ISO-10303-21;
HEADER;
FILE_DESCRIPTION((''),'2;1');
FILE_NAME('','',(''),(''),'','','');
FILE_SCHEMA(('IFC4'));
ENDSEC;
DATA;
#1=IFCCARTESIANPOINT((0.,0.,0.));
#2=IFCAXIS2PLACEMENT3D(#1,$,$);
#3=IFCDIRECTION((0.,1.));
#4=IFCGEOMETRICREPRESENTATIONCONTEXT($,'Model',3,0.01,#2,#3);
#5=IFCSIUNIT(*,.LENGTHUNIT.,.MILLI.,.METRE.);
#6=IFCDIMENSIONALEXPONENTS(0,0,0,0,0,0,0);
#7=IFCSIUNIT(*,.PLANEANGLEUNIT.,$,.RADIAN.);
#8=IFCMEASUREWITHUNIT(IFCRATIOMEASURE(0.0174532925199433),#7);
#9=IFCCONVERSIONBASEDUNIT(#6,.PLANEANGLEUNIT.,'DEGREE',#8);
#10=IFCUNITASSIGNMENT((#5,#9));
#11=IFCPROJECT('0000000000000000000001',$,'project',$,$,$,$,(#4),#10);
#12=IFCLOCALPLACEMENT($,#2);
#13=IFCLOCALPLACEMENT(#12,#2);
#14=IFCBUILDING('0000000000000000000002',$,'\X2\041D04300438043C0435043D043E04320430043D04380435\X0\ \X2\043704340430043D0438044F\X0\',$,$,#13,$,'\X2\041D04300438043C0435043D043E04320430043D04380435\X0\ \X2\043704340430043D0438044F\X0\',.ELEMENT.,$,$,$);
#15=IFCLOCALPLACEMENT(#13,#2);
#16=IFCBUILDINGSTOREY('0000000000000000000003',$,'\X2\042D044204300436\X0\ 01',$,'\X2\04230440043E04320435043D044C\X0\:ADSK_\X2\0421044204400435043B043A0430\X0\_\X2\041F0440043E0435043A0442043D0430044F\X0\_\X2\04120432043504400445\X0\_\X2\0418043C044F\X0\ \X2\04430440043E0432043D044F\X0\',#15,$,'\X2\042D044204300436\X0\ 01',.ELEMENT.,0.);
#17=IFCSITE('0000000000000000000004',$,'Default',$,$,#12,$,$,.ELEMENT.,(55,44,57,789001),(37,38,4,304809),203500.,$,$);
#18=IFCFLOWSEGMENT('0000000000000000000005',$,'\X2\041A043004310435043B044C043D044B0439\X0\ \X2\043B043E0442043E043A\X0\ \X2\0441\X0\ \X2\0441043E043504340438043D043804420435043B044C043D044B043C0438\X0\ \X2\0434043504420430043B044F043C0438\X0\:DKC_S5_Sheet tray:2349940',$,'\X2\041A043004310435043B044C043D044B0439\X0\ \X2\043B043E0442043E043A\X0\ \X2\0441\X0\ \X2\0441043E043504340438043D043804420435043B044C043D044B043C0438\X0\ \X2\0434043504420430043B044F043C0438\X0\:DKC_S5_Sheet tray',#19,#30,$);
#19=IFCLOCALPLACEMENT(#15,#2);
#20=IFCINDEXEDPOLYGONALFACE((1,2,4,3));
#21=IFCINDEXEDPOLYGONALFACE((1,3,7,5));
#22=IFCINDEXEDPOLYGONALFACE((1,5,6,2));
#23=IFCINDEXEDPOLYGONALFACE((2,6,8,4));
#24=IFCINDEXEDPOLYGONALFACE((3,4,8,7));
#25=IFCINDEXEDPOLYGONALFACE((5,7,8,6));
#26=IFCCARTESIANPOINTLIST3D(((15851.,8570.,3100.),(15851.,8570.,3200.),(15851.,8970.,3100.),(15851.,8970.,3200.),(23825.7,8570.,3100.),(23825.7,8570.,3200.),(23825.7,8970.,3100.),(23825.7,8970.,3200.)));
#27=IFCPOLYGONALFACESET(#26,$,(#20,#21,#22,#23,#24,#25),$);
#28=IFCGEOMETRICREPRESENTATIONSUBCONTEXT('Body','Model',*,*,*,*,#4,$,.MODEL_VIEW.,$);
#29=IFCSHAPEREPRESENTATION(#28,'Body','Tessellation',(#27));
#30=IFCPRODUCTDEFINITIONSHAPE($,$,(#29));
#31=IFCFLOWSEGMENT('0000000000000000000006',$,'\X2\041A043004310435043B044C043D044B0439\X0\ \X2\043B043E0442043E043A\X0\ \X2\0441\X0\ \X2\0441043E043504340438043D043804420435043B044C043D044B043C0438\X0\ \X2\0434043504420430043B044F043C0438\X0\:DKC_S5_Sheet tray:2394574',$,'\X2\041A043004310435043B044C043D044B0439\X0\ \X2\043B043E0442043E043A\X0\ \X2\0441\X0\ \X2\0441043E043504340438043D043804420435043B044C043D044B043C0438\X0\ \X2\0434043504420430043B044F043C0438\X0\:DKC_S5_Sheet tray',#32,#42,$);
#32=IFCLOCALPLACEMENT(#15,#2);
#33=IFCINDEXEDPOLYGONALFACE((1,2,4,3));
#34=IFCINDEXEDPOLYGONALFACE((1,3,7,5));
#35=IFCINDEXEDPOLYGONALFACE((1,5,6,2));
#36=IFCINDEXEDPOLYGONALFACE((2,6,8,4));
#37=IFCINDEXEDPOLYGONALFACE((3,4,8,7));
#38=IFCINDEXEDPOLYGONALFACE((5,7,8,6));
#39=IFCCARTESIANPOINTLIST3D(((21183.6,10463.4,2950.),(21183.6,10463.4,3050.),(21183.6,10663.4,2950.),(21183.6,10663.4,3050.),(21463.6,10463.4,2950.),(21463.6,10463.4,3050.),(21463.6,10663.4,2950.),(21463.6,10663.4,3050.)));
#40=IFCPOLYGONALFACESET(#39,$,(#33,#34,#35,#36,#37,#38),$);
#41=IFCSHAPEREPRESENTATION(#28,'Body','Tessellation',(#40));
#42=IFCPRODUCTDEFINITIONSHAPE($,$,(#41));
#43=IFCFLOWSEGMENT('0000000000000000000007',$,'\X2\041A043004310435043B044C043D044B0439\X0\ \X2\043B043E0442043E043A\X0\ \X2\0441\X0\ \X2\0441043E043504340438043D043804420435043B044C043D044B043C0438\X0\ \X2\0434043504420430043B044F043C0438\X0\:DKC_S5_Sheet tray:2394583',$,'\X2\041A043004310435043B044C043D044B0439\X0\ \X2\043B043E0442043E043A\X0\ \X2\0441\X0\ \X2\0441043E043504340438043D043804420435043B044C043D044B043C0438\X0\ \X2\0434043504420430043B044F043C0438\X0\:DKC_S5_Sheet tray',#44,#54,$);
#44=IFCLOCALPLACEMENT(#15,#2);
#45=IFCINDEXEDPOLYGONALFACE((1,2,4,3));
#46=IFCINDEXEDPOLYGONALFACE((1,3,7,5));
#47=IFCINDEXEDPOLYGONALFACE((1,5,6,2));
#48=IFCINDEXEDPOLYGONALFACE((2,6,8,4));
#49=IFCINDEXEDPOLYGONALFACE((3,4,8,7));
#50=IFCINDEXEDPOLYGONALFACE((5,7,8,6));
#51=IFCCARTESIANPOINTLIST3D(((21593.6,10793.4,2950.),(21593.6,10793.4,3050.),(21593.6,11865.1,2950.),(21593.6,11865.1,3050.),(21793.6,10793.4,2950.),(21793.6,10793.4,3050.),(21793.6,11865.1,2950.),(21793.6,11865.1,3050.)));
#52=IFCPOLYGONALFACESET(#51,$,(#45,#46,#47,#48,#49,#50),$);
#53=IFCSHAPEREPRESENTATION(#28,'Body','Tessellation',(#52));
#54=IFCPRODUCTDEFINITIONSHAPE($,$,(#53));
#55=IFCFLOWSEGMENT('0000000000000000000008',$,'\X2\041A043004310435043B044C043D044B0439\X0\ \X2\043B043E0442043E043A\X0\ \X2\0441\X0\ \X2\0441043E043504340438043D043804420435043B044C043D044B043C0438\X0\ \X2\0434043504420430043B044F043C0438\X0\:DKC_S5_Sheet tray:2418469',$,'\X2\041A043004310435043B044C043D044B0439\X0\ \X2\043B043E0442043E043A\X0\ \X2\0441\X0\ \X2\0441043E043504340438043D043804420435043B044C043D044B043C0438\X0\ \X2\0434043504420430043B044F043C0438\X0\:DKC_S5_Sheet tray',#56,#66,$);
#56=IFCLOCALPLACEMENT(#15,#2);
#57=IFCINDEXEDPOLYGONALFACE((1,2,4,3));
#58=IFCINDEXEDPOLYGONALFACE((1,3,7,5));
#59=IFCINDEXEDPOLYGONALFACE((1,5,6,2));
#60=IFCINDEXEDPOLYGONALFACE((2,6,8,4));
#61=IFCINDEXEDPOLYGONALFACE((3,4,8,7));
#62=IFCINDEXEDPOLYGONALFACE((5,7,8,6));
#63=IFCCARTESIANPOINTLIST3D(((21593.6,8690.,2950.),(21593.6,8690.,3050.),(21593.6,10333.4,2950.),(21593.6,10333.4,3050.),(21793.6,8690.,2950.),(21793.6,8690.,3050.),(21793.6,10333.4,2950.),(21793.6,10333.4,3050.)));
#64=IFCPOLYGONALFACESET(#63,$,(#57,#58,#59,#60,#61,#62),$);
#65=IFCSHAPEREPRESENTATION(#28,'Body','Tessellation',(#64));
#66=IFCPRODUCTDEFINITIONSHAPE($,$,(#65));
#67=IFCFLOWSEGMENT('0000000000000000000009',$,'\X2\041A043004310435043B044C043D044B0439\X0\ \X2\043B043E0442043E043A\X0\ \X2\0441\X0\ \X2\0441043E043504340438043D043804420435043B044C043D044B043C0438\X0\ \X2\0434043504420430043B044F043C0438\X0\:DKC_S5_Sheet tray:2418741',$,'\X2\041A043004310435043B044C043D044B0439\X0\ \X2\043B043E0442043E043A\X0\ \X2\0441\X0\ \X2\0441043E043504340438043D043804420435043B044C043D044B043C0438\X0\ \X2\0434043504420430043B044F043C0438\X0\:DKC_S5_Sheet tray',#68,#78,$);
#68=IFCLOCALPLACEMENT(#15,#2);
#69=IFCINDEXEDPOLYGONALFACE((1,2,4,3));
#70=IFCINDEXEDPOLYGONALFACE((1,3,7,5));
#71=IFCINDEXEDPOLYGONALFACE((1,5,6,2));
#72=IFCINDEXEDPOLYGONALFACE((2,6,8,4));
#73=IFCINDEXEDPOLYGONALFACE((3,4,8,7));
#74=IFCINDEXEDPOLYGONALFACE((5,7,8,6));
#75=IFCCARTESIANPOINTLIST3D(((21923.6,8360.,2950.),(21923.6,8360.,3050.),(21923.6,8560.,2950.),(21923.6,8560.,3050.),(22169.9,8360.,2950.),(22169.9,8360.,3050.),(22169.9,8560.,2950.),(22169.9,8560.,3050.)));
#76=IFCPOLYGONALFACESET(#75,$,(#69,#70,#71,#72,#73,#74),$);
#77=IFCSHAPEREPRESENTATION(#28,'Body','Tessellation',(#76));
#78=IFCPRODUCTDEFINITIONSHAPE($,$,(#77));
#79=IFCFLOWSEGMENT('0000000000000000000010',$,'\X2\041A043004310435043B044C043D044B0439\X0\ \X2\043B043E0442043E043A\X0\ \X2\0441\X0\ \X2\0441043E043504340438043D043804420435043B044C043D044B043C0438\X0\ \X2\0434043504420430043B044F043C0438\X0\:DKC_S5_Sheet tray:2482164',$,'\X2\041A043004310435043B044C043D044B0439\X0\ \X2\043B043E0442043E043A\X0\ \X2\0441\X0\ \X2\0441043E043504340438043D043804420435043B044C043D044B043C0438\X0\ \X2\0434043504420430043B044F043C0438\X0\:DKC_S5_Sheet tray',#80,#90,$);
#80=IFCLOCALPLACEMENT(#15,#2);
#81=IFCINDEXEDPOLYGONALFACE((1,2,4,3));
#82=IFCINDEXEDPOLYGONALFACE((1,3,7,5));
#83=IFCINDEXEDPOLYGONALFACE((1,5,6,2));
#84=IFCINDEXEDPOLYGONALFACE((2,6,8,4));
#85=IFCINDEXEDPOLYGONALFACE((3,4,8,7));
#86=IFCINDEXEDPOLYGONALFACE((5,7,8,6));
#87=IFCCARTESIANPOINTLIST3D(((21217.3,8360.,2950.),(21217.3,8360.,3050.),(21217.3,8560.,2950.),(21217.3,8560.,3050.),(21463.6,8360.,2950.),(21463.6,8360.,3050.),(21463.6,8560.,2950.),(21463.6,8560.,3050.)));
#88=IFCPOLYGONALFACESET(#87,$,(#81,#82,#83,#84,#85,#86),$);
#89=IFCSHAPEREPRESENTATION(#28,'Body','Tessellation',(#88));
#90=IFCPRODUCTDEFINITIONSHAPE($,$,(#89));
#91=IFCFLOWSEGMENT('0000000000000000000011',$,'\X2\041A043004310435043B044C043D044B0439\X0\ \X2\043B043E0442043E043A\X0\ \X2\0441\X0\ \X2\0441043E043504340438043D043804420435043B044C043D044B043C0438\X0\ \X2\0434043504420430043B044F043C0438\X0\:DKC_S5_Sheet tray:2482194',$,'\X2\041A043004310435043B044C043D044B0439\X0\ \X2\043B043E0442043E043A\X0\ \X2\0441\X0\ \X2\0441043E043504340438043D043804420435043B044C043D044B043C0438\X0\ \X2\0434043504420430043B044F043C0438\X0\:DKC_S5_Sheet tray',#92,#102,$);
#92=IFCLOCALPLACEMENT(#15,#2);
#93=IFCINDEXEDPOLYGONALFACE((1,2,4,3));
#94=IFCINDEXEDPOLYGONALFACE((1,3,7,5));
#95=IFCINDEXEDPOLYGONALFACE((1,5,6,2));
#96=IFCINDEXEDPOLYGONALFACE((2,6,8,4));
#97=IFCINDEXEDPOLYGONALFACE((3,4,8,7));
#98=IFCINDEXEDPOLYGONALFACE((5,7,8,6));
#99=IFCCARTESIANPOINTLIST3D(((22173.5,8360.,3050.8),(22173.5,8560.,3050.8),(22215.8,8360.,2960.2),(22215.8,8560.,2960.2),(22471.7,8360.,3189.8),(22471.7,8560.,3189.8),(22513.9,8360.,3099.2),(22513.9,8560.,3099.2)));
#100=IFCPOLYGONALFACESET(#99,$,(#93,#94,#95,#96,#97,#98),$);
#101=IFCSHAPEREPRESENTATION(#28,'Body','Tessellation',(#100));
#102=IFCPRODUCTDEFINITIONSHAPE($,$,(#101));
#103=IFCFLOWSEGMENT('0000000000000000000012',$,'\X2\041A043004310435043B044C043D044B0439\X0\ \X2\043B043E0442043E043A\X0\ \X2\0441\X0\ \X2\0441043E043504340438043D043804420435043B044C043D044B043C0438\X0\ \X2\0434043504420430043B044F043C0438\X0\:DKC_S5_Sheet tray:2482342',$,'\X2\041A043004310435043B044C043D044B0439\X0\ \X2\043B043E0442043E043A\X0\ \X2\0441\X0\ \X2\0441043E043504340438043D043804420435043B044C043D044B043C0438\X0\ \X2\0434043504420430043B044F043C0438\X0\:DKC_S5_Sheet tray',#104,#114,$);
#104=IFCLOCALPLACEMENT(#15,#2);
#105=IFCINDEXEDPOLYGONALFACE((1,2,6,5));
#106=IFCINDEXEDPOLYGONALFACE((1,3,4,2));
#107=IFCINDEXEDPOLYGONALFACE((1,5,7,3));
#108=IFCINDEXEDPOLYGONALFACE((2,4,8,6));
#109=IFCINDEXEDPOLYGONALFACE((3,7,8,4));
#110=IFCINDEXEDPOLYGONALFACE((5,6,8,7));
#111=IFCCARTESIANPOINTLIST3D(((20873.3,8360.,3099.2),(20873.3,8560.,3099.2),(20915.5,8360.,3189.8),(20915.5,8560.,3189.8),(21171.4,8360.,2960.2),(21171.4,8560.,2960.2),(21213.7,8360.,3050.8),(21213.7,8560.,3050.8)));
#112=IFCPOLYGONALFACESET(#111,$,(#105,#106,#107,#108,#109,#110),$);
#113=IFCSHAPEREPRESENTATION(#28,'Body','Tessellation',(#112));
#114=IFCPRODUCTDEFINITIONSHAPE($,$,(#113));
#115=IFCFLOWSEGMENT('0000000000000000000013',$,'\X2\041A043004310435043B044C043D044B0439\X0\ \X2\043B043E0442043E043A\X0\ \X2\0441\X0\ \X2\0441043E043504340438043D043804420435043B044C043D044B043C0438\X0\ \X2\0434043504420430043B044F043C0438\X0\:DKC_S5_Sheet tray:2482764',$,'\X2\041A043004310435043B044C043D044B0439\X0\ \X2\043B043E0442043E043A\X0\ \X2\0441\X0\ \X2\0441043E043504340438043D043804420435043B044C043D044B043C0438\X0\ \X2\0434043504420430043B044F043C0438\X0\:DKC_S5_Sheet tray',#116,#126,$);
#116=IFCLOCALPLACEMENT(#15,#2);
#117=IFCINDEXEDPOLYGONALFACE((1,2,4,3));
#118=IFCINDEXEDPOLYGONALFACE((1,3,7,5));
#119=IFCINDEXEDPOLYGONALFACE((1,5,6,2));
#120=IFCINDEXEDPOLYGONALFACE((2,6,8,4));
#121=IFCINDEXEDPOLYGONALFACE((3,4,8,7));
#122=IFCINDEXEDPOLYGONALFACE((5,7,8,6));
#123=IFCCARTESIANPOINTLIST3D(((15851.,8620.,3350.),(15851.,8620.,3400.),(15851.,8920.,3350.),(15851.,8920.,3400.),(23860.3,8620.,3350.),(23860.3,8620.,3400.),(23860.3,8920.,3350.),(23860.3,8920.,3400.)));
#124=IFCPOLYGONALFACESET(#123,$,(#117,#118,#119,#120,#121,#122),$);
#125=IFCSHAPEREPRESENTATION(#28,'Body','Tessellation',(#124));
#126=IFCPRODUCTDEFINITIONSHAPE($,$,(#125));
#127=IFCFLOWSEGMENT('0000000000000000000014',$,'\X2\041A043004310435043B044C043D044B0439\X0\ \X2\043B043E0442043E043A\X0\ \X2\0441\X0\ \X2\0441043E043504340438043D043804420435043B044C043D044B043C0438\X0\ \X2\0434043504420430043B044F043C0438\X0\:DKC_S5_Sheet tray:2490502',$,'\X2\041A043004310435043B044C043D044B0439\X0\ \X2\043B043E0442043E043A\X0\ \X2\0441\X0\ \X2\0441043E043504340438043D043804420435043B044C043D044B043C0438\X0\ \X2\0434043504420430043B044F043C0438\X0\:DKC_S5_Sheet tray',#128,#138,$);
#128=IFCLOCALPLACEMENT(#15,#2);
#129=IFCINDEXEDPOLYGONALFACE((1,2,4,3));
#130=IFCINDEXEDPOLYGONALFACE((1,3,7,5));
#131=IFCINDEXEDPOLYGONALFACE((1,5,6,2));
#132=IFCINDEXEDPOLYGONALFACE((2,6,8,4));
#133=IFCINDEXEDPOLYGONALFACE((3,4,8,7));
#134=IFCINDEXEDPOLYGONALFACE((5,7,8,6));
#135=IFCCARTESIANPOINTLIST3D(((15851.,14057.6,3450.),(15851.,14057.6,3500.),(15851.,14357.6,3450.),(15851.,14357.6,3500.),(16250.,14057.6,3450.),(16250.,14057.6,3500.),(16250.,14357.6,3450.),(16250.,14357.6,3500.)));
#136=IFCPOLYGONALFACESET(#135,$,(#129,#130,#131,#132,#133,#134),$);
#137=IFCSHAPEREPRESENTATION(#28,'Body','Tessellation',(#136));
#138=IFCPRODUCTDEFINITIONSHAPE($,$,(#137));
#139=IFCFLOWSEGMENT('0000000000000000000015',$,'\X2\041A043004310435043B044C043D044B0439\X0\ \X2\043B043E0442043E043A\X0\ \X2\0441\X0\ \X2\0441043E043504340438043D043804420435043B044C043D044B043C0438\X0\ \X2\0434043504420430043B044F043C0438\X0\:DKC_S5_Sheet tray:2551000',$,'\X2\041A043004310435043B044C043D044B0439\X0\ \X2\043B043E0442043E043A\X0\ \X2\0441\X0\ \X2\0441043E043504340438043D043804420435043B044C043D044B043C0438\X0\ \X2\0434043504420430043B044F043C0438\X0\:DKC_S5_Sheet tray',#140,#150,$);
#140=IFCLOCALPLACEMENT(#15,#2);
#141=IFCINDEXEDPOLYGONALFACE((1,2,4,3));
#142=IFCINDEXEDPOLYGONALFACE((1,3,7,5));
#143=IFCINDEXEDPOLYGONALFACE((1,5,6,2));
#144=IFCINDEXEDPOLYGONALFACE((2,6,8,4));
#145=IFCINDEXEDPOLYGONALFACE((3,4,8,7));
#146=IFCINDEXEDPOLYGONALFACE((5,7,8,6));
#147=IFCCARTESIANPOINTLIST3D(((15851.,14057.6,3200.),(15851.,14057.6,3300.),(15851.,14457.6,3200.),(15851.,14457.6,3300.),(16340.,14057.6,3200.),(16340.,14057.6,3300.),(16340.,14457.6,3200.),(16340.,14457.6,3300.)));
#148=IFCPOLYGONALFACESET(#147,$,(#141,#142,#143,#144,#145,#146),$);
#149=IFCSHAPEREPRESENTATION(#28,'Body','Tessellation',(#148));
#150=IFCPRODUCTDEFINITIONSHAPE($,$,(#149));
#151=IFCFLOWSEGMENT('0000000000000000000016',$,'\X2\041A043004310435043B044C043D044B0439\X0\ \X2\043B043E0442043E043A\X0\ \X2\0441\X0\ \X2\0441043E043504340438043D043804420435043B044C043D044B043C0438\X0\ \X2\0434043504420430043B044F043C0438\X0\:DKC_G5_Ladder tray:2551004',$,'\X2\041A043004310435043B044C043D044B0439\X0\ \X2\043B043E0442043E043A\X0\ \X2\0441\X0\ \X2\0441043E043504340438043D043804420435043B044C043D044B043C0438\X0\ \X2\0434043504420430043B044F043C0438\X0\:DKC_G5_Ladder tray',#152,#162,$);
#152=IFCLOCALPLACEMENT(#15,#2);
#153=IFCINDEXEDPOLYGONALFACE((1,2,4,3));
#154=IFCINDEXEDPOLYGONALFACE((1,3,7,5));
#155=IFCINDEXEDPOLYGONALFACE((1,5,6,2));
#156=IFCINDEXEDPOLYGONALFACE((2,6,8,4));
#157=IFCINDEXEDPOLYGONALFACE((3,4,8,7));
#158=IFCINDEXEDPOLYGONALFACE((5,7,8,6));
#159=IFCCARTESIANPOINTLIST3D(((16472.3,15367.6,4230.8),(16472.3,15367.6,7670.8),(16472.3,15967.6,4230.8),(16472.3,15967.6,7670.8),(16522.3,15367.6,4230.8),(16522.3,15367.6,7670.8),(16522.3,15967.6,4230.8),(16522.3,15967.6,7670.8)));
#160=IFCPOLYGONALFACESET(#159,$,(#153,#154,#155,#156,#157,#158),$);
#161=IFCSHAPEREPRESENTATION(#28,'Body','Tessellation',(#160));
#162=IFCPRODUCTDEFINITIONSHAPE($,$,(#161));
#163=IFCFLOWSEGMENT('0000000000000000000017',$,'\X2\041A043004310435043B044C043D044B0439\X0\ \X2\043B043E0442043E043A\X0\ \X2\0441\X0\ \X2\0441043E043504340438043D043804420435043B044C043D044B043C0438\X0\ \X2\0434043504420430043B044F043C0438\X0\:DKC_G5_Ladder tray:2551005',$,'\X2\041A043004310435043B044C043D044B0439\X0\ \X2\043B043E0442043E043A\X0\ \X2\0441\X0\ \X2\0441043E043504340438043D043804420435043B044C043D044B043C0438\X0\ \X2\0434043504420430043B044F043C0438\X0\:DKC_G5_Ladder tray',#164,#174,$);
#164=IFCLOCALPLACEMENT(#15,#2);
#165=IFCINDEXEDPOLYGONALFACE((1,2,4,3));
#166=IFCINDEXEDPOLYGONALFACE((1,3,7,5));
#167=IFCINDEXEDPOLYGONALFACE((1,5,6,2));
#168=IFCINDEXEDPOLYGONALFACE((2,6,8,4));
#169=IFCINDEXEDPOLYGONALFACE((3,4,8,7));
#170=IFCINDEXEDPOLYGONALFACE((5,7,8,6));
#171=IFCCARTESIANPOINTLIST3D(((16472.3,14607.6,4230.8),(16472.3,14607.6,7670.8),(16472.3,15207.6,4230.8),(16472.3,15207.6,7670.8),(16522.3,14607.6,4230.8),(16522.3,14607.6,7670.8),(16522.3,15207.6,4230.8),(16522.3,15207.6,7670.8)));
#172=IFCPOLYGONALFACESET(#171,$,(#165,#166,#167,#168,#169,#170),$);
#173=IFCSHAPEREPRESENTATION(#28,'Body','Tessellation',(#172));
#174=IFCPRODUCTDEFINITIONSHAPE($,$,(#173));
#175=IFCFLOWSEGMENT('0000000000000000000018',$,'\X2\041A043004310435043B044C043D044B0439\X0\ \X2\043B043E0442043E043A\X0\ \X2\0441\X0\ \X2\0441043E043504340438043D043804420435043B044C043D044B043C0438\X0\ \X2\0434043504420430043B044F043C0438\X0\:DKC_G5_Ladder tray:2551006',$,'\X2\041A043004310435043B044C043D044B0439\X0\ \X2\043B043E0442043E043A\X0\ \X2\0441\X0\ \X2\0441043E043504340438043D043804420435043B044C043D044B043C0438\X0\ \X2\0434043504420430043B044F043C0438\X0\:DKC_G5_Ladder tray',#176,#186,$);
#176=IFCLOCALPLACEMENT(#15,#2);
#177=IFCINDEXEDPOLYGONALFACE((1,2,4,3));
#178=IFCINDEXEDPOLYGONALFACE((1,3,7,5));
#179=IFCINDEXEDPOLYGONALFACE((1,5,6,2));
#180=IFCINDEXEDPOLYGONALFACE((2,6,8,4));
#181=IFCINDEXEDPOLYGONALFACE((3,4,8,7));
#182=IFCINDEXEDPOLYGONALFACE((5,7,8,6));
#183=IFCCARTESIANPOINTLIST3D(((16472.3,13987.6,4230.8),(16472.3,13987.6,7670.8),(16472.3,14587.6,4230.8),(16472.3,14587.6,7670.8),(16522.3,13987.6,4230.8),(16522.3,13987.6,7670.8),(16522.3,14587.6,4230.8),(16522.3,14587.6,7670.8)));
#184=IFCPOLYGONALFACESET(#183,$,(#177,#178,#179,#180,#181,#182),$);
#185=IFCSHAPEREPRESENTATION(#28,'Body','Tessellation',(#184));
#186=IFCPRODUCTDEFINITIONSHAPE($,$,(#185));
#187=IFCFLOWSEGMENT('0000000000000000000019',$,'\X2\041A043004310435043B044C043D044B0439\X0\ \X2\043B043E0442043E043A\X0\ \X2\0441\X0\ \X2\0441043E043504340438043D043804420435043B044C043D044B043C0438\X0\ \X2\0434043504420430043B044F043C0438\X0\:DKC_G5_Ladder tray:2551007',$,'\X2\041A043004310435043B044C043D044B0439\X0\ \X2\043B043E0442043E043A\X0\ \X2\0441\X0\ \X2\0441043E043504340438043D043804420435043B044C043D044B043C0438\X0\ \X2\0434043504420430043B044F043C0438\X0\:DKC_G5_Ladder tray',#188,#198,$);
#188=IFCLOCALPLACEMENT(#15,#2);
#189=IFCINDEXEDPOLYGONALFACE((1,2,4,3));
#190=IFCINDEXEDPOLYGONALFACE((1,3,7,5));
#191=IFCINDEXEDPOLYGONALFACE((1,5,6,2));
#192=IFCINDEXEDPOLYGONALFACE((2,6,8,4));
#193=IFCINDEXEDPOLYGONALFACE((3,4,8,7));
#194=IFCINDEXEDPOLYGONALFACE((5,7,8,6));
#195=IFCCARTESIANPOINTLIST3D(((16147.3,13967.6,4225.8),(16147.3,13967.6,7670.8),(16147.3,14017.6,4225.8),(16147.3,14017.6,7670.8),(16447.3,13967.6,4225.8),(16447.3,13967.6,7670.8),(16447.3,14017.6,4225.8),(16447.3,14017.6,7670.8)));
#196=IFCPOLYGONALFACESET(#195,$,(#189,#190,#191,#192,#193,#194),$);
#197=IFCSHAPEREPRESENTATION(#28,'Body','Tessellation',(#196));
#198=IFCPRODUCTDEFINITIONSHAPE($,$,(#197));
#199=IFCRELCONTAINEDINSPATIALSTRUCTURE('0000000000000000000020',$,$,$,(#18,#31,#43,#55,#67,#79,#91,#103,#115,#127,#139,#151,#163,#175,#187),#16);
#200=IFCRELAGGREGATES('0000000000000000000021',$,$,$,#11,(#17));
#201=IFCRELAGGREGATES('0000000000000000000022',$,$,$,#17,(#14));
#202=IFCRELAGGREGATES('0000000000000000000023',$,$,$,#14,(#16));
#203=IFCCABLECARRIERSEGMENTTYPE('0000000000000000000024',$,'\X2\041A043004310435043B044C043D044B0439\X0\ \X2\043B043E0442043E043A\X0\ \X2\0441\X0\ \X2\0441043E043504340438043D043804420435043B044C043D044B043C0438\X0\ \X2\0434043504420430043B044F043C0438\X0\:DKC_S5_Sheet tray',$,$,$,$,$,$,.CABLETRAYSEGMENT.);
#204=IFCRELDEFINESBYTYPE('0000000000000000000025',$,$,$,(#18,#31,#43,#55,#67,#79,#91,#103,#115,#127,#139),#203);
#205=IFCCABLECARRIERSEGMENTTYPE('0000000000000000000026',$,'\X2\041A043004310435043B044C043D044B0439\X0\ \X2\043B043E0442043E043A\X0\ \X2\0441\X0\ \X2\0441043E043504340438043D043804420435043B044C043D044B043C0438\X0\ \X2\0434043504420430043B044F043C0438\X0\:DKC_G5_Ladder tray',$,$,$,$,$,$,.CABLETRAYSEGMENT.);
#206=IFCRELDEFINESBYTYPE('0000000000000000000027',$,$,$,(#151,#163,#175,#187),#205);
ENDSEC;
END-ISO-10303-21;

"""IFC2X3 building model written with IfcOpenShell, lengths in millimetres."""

from ifc_helpers import new_model, entity, si_unit, converted_unit, direction, frame, frame_2d, origin, origin_2d_with_axis, place, context, subcontext, project, spatial, rectangle, extrude, type_object, element, save


model = new_model("IFC2X3")

# Units and contexts
model_context = context("Model", 3, precision=0.01, world=origin(), true_north=direction((0.0, 1.0)))
body_context = subcontext(model_context, "Body", "Model", "MODEL_VIEW")
ifc_project = project(units=[si_unit("LENGTHUNIT", "METRE", prefix="MILLI"), converted_unit("PLANEANGLEUNIT", "DEGREE", entity("IfcRatioMeasure", 0.0174532925199433), si_unit("PLANEANGLEUNIT", "RADIAN"), dimensions=[0, 0, 0, 0, 0, 0, 0])], contexts=[model_context])

# Site, building, storey
site_placement = place(None, origin())
site = spatial("IfcSite", under=ifc_project, at=site_placement, Name="Default", CompositionType="ELEMENT", RefLatitude=(55, 44, 57, 789001), RefLongitude=(37, 38, 4, 304809), RefElevation=203500.0)
building_placement = place(site_placement, origin())
building = spatial("IfcBuilding", under=site, at=building_placement, Name="Наименование здания", LongName="Наименование здания", CompositionType="ELEMENT")
storey_placement = place(building_placement, origin())
storey = spatial("IfcBuildingStorey", under=building, at=storey_placement, Name="Этаж 01", ObjectType="Уровень:ADSK_Стрелка_Проектная_Вверх_Имя уровня", LongName="Этаж 01", CompositionType="ELEMENT", Elevation=0.0)

# Flow segments
cable_carrier_segment_type_1 = type_object("IfcCableCarrierSegmentType", Name="Кабельный лоток с соединительными деталями:DKC_S5_Sheet tray", PredefinedType="CABLETRAYSEGMENT")
flow_segment_1_placement = place(storey_placement, frame((15851.0, 8570.0, 3100.0)))
element("IfcFlowSegment", 1, at=flow_segment_1_placement, inside=storey, type_object=cable_carrier_segment_type_1, Name="Кабельный лоток с соединительными деталями:DKC_S5_Sheet tray:2349940", ObjectType="Кабельный лоток с соединительными деталями:DKC_S5_Sheet tray", context=body_context, shape_type="SweptSolid", body=[
    extrude(rectangle(XDim=7974.7, YDim=400.0, at=origin_2d_with_axis()), frame((3987.3, 200.0, 0.0)), (0.0, 0.0, 1.0), 100.0),
])
flow_segment_2_placement = place(storey_placement, frame((21183.6, 10463.4, 2950.0)))
element("IfcFlowSegment", 2, at=flow_segment_2_placement, inside=storey, type_object=cable_carrier_segment_type_1, Name="Кабельный лоток с соединительными деталями:DKC_S5_Sheet tray:2394574", ObjectType="Кабельный лоток с соединительными деталями:DKC_S5_Sheet tray", context=body_context, shape_type="SweptSolid", body=[
    extrude(rectangle(XDim=280.0, YDim=200.0, at=origin_2d_with_axis()), frame((140.0, 100.0, 0.0), z_axis=(0.0, 0.0, 1.0), x_axis=(-1.0, 0.0, 0.0)), (0.0, 0.0, 1.0), 100.0),
])
flow_segment_3_placement = place(storey_placement, frame((21593.6, 10793.4, 2950.0)))
element("IfcFlowSegment", 3, at=flow_segment_3_placement, inside=storey, type_object=cable_carrier_segment_type_1, Name="Кабельный лоток с соединительными деталями:DKC_S5_Sheet tray:2394583", ObjectType="Кабельный лоток с соединительными деталями:DKC_S5_Sheet tray", context=body_context, shape_type="SweptSolid", body=[
    extrude(rectangle(XDim=1071.7, YDim=200.0, at=origin_2d_with_axis()), frame((100.0, 535.9, 0.0), z_axis=(0.0, 0.0, 1.0), x_axis=(0.0, -1.0, 0.0)), (0.0, 0.0, 1.0), 100.0),
])
flow_segment_4_placement = place(storey_placement, frame((21593.6, 8690.0, 2950.0)))
element("IfcFlowSegment", 4, at=flow_segment_4_placement, inside=storey, type_object=cable_carrier_segment_type_1, Name="Кабельный лоток с соединительными деталями:DKC_S5_Sheet tray:2418469", ObjectType="Кабельный лоток с соединительными деталями:DKC_S5_Sheet tray", context=body_context, shape_type="SweptSolid", body=[
    extrude(rectangle(XDim=1643.4, YDim=200.0, at=origin_2d_with_axis()), frame((100.0, 821.7, 0.0), z_axis=(0.0, 0.0, 1.0), x_axis=(0.0, -1.0, 0.0)), (0.0, 0.0, 1.0), 100.0),
])
flow_segment_5_placement = place(storey_placement, frame((21923.6, 8360.0, 2950.0)))
element("IfcFlowSegment", 5, at=flow_segment_5_placement, inside=storey, type_object=cable_carrier_segment_type_1, Name="Кабельный лоток с соединительными деталями:DKC_S5_Sheet tray:2418741", ObjectType="Кабельный лоток с соединительными деталями:DKC_S5_Sheet tray", context=body_context, shape_type="SweptSolid", body=[
    extrude(rectangle(XDim=246.3, YDim=200.0, at=origin_2d_with_axis()), frame((123.2, 100.0, 0.0)), (0.0, 0.0, 1.0), 100.0),
])
flow_segment_6_placement = place(storey_placement, frame((21217.3, 8360.0, 2950.0)))
element("IfcFlowSegment", 6, at=flow_segment_6_placement, inside=storey, type_object=cable_carrier_segment_type_1, Name="Кабельный лоток с соединительными деталями:DKC_S5_Sheet tray:2482164", ObjectType="Кабельный лоток с соединительными деталями:DKC_S5_Sheet tray", context=body_context, shape_type="SweptSolid", body=[
    extrude(rectangle(XDim=246.3, YDim=200.0, at=origin_2d_with_axis()), frame((123.2, 100.0, 0.0), z_axis=(0.0, 0.0, 1.0), x_axis=(-1.0, 0.0, 0.0)), (0.0, 0.0, 1.0), 100.0),
])
flow_segment_7_placement = place(storey_placement, frame((22173.5, 8360.0, 2960.2)))
element("IfcFlowSegment", 7, at=flow_segment_7_placement, inside=storey, type_object=cable_carrier_segment_type_1, Name="Кабельный лоток с соединительными деталями:DKC_S5_Sheet tray:2482194", ObjectType="Кабельный лоток с соединительными деталями:DKC_S5_Sheet tray", context=body_context, shape_type="SweptSolid", body=[
    extrude(rectangle(XDim=100.0, YDim=200.0, at=origin_2d_with_axis()), frame((21.1, 100.0, 45.3), z_axis=(0.906308, 0.0, 0.422618), x_axis=(-0.422618, 0.0, 0.906308)), (0.0, 0.0, 1.0), 329.0),
])
flow_segment_8_placement = place(storey_placement, frame((20873.3, 8360.0, 2960.2)))
element("IfcFlowSegment", 8, at=flow_segment_8_placement, inside=storey, type_object=cable_carrier_segment_type_1, Name="Кабельный лоток с соединительными деталями:DKC_S5_Sheet tray:2482342", ObjectType="Кабельный лоток с соединительными деталями:DKC_S5_Sheet tray", context=body_context, shape_type="SweptSolid", body=[
    extrude(rectangle(XDim=100.0, YDim=200.0, at=frame_2d((0.0, 0.0), x_axis=(0.0, 1.0))), frame((21.1, 100.0, 184.3), z_axis=(0.906308, 0.0, -0.422618), x_axis=(0.0, 1.0, 0.0)), (0.0, 0.0, 1.0), 329.0),
])
flow_segment_9_placement = place(storey_placement, frame((15851.0, 8620.0, 3350.0)))
element("IfcFlowSegment", 9, at=flow_segment_9_placement, inside=storey, type_object=cable_carrier_segment_type_1, Name="Кабельный лоток с соединительными деталями:DKC_S5_Sheet tray:2482764", ObjectType="Кабельный лоток с соединительными деталями:DKC_S5_Sheet tray", context=body_context, shape_type="SweptSolid", body=[
    extrude(rectangle(XDim=8009.3, YDim=300.0, at=origin_2d_with_axis()), frame((4004.7, 150.0, 0.0)), (0.0, 0.0, 1.0), 50.0),
])
flow_segment_10_placement = place(storey_placement, frame((15851.0, 14057.6, 3450.0)))
element("IfcFlowSegment", 10, at=flow_segment_10_placement, inside=storey, type_object=cable_carrier_segment_type_1, Name="Кабельный лоток с соединительными деталями:DKC_S5_Sheet tray:2490502", ObjectType="Кабельный лоток с соединительными деталями:DKC_S5_Sheet tray", context=body_context, shape_type="SweptSolid", body=[
    extrude(rectangle(XDim=399.0, YDim=300.0, at=origin_2d_with_axis()), frame((199.5, 150.0, 0.0)), (0.0, 0.0, 1.0), 50.0),
])
flow_segment_11_placement = place(storey_placement, frame((15851.0, 14057.6, 3200.0)))
element("IfcFlowSegment", 11, at=flow_segment_11_placement, inside=storey, type_object=cable_carrier_segment_type_1, Name="Кабельный лоток с соединительными деталями:DKC_S5_Sheet tray:2551000", ObjectType="Кабельный лоток с соединительными деталями:DKC_S5_Sheet tray", context=body_context, shape_type="SweptSolid", body=[
    extrude(rectangle(XDim=489.0, YDim=400.0, at=origin_2d_with_axis()), frame((244.5, 200.0, 0.0)), (0.0, 0.0, 1.0), 100.0),
])
cable_carrier_segment_type_2 = type_object("IfcCableCarrierSegmentType", Name="Кабельный лоток с соединительными деталями:DKC_G5_Ladder tray", PredefinedType="CABLETRAYSEGMENT")
for number, where, name in (
    (12, (16472.3, 15367.6, 4230.8), "Кабельный лоток с соединительными деталями:DKC_G5_Ladder tray:2551004"),
    (13, (16472.3, 14607.6, 4230.8), "Кабельный лоток с соединительными деталями:DKC_G5_Ladder tray:2551005"),
):
    element("IfcFlowSegment", number, at=place(storey_placement, frame(where)), inside=storey, type_object=cable_carrier_segment_type_2, Name=name, ObjectType="Кабельный лоток с соединительными деталями:DKC_G5_Ladder tray", context=body_context, shape_type="SweptSolid", body=[
        extrude(rectangle(XDim=50.0, YDim=600.0, at=origin_2d_with_axis()), frame((25.0, 300.0, 0.0), z_axis=(0.0, 0.0, 1.0), x_axis=(-1.0, 0.0, 0.0)), (0.0, 0.0, 1.0), 3440.0),
    ])
flow_segment_12_placement = place(storey_placement, frame((16472.3, 13987.6, 4230.8)))
element("IfcFlowSegment", 14, at=flow_segment_12_placement, inside=storey, type_object=cable_carrier_segment_type_2, Name="Кабельный лоток с соединительными деталями:DKC_G5_Ladder tray:2551006", ObjectType="Кабельный лоток с соединительными деталями:DKC_G5_Ladder tray", context=body_context, shape_type="SweptSolid", body=[
    extrude(rectangle(XDim=50.0, YDim=600.0, at=origin_2d_with_axis()), frame((25.0, 300.0, 0.0), z_axis=(0.0, 0.0, 1.0), x_axis=(-1.0, 0.0, 0.0)), (0.0, 0.0, 1.0), 3440.0),
])
flow_segment_13_placement = place(storey_placement, frame((16147.3, 13967.6, 4225.8)))
element("IfcFlowSegment", 15, at=flow_segment_13_placement, inside=storey, type_object=cable_carrier_segment_type_2, Name="Кабельный лоток с соединительными деталями:DKC_G5_Ladder tray:2551007", ObjectType="Кабельный лоток с соединительными деталями:DKC_G5_Ladder tray", context=body_context, shape_type="SweptSolid", body=[
    extrude(rectangle(XDim=50.0, YDim=300.0, at=origin_2d_with_axis()), frame((150.0, 25.0, 0.0), z_axis=(0.0, 0.0, 1.0), x_axis=(0.0, 1.0, 0.0)), (0.0, 0.0, 1.0), 3445.0),
])

save(model, "model.ifc")
